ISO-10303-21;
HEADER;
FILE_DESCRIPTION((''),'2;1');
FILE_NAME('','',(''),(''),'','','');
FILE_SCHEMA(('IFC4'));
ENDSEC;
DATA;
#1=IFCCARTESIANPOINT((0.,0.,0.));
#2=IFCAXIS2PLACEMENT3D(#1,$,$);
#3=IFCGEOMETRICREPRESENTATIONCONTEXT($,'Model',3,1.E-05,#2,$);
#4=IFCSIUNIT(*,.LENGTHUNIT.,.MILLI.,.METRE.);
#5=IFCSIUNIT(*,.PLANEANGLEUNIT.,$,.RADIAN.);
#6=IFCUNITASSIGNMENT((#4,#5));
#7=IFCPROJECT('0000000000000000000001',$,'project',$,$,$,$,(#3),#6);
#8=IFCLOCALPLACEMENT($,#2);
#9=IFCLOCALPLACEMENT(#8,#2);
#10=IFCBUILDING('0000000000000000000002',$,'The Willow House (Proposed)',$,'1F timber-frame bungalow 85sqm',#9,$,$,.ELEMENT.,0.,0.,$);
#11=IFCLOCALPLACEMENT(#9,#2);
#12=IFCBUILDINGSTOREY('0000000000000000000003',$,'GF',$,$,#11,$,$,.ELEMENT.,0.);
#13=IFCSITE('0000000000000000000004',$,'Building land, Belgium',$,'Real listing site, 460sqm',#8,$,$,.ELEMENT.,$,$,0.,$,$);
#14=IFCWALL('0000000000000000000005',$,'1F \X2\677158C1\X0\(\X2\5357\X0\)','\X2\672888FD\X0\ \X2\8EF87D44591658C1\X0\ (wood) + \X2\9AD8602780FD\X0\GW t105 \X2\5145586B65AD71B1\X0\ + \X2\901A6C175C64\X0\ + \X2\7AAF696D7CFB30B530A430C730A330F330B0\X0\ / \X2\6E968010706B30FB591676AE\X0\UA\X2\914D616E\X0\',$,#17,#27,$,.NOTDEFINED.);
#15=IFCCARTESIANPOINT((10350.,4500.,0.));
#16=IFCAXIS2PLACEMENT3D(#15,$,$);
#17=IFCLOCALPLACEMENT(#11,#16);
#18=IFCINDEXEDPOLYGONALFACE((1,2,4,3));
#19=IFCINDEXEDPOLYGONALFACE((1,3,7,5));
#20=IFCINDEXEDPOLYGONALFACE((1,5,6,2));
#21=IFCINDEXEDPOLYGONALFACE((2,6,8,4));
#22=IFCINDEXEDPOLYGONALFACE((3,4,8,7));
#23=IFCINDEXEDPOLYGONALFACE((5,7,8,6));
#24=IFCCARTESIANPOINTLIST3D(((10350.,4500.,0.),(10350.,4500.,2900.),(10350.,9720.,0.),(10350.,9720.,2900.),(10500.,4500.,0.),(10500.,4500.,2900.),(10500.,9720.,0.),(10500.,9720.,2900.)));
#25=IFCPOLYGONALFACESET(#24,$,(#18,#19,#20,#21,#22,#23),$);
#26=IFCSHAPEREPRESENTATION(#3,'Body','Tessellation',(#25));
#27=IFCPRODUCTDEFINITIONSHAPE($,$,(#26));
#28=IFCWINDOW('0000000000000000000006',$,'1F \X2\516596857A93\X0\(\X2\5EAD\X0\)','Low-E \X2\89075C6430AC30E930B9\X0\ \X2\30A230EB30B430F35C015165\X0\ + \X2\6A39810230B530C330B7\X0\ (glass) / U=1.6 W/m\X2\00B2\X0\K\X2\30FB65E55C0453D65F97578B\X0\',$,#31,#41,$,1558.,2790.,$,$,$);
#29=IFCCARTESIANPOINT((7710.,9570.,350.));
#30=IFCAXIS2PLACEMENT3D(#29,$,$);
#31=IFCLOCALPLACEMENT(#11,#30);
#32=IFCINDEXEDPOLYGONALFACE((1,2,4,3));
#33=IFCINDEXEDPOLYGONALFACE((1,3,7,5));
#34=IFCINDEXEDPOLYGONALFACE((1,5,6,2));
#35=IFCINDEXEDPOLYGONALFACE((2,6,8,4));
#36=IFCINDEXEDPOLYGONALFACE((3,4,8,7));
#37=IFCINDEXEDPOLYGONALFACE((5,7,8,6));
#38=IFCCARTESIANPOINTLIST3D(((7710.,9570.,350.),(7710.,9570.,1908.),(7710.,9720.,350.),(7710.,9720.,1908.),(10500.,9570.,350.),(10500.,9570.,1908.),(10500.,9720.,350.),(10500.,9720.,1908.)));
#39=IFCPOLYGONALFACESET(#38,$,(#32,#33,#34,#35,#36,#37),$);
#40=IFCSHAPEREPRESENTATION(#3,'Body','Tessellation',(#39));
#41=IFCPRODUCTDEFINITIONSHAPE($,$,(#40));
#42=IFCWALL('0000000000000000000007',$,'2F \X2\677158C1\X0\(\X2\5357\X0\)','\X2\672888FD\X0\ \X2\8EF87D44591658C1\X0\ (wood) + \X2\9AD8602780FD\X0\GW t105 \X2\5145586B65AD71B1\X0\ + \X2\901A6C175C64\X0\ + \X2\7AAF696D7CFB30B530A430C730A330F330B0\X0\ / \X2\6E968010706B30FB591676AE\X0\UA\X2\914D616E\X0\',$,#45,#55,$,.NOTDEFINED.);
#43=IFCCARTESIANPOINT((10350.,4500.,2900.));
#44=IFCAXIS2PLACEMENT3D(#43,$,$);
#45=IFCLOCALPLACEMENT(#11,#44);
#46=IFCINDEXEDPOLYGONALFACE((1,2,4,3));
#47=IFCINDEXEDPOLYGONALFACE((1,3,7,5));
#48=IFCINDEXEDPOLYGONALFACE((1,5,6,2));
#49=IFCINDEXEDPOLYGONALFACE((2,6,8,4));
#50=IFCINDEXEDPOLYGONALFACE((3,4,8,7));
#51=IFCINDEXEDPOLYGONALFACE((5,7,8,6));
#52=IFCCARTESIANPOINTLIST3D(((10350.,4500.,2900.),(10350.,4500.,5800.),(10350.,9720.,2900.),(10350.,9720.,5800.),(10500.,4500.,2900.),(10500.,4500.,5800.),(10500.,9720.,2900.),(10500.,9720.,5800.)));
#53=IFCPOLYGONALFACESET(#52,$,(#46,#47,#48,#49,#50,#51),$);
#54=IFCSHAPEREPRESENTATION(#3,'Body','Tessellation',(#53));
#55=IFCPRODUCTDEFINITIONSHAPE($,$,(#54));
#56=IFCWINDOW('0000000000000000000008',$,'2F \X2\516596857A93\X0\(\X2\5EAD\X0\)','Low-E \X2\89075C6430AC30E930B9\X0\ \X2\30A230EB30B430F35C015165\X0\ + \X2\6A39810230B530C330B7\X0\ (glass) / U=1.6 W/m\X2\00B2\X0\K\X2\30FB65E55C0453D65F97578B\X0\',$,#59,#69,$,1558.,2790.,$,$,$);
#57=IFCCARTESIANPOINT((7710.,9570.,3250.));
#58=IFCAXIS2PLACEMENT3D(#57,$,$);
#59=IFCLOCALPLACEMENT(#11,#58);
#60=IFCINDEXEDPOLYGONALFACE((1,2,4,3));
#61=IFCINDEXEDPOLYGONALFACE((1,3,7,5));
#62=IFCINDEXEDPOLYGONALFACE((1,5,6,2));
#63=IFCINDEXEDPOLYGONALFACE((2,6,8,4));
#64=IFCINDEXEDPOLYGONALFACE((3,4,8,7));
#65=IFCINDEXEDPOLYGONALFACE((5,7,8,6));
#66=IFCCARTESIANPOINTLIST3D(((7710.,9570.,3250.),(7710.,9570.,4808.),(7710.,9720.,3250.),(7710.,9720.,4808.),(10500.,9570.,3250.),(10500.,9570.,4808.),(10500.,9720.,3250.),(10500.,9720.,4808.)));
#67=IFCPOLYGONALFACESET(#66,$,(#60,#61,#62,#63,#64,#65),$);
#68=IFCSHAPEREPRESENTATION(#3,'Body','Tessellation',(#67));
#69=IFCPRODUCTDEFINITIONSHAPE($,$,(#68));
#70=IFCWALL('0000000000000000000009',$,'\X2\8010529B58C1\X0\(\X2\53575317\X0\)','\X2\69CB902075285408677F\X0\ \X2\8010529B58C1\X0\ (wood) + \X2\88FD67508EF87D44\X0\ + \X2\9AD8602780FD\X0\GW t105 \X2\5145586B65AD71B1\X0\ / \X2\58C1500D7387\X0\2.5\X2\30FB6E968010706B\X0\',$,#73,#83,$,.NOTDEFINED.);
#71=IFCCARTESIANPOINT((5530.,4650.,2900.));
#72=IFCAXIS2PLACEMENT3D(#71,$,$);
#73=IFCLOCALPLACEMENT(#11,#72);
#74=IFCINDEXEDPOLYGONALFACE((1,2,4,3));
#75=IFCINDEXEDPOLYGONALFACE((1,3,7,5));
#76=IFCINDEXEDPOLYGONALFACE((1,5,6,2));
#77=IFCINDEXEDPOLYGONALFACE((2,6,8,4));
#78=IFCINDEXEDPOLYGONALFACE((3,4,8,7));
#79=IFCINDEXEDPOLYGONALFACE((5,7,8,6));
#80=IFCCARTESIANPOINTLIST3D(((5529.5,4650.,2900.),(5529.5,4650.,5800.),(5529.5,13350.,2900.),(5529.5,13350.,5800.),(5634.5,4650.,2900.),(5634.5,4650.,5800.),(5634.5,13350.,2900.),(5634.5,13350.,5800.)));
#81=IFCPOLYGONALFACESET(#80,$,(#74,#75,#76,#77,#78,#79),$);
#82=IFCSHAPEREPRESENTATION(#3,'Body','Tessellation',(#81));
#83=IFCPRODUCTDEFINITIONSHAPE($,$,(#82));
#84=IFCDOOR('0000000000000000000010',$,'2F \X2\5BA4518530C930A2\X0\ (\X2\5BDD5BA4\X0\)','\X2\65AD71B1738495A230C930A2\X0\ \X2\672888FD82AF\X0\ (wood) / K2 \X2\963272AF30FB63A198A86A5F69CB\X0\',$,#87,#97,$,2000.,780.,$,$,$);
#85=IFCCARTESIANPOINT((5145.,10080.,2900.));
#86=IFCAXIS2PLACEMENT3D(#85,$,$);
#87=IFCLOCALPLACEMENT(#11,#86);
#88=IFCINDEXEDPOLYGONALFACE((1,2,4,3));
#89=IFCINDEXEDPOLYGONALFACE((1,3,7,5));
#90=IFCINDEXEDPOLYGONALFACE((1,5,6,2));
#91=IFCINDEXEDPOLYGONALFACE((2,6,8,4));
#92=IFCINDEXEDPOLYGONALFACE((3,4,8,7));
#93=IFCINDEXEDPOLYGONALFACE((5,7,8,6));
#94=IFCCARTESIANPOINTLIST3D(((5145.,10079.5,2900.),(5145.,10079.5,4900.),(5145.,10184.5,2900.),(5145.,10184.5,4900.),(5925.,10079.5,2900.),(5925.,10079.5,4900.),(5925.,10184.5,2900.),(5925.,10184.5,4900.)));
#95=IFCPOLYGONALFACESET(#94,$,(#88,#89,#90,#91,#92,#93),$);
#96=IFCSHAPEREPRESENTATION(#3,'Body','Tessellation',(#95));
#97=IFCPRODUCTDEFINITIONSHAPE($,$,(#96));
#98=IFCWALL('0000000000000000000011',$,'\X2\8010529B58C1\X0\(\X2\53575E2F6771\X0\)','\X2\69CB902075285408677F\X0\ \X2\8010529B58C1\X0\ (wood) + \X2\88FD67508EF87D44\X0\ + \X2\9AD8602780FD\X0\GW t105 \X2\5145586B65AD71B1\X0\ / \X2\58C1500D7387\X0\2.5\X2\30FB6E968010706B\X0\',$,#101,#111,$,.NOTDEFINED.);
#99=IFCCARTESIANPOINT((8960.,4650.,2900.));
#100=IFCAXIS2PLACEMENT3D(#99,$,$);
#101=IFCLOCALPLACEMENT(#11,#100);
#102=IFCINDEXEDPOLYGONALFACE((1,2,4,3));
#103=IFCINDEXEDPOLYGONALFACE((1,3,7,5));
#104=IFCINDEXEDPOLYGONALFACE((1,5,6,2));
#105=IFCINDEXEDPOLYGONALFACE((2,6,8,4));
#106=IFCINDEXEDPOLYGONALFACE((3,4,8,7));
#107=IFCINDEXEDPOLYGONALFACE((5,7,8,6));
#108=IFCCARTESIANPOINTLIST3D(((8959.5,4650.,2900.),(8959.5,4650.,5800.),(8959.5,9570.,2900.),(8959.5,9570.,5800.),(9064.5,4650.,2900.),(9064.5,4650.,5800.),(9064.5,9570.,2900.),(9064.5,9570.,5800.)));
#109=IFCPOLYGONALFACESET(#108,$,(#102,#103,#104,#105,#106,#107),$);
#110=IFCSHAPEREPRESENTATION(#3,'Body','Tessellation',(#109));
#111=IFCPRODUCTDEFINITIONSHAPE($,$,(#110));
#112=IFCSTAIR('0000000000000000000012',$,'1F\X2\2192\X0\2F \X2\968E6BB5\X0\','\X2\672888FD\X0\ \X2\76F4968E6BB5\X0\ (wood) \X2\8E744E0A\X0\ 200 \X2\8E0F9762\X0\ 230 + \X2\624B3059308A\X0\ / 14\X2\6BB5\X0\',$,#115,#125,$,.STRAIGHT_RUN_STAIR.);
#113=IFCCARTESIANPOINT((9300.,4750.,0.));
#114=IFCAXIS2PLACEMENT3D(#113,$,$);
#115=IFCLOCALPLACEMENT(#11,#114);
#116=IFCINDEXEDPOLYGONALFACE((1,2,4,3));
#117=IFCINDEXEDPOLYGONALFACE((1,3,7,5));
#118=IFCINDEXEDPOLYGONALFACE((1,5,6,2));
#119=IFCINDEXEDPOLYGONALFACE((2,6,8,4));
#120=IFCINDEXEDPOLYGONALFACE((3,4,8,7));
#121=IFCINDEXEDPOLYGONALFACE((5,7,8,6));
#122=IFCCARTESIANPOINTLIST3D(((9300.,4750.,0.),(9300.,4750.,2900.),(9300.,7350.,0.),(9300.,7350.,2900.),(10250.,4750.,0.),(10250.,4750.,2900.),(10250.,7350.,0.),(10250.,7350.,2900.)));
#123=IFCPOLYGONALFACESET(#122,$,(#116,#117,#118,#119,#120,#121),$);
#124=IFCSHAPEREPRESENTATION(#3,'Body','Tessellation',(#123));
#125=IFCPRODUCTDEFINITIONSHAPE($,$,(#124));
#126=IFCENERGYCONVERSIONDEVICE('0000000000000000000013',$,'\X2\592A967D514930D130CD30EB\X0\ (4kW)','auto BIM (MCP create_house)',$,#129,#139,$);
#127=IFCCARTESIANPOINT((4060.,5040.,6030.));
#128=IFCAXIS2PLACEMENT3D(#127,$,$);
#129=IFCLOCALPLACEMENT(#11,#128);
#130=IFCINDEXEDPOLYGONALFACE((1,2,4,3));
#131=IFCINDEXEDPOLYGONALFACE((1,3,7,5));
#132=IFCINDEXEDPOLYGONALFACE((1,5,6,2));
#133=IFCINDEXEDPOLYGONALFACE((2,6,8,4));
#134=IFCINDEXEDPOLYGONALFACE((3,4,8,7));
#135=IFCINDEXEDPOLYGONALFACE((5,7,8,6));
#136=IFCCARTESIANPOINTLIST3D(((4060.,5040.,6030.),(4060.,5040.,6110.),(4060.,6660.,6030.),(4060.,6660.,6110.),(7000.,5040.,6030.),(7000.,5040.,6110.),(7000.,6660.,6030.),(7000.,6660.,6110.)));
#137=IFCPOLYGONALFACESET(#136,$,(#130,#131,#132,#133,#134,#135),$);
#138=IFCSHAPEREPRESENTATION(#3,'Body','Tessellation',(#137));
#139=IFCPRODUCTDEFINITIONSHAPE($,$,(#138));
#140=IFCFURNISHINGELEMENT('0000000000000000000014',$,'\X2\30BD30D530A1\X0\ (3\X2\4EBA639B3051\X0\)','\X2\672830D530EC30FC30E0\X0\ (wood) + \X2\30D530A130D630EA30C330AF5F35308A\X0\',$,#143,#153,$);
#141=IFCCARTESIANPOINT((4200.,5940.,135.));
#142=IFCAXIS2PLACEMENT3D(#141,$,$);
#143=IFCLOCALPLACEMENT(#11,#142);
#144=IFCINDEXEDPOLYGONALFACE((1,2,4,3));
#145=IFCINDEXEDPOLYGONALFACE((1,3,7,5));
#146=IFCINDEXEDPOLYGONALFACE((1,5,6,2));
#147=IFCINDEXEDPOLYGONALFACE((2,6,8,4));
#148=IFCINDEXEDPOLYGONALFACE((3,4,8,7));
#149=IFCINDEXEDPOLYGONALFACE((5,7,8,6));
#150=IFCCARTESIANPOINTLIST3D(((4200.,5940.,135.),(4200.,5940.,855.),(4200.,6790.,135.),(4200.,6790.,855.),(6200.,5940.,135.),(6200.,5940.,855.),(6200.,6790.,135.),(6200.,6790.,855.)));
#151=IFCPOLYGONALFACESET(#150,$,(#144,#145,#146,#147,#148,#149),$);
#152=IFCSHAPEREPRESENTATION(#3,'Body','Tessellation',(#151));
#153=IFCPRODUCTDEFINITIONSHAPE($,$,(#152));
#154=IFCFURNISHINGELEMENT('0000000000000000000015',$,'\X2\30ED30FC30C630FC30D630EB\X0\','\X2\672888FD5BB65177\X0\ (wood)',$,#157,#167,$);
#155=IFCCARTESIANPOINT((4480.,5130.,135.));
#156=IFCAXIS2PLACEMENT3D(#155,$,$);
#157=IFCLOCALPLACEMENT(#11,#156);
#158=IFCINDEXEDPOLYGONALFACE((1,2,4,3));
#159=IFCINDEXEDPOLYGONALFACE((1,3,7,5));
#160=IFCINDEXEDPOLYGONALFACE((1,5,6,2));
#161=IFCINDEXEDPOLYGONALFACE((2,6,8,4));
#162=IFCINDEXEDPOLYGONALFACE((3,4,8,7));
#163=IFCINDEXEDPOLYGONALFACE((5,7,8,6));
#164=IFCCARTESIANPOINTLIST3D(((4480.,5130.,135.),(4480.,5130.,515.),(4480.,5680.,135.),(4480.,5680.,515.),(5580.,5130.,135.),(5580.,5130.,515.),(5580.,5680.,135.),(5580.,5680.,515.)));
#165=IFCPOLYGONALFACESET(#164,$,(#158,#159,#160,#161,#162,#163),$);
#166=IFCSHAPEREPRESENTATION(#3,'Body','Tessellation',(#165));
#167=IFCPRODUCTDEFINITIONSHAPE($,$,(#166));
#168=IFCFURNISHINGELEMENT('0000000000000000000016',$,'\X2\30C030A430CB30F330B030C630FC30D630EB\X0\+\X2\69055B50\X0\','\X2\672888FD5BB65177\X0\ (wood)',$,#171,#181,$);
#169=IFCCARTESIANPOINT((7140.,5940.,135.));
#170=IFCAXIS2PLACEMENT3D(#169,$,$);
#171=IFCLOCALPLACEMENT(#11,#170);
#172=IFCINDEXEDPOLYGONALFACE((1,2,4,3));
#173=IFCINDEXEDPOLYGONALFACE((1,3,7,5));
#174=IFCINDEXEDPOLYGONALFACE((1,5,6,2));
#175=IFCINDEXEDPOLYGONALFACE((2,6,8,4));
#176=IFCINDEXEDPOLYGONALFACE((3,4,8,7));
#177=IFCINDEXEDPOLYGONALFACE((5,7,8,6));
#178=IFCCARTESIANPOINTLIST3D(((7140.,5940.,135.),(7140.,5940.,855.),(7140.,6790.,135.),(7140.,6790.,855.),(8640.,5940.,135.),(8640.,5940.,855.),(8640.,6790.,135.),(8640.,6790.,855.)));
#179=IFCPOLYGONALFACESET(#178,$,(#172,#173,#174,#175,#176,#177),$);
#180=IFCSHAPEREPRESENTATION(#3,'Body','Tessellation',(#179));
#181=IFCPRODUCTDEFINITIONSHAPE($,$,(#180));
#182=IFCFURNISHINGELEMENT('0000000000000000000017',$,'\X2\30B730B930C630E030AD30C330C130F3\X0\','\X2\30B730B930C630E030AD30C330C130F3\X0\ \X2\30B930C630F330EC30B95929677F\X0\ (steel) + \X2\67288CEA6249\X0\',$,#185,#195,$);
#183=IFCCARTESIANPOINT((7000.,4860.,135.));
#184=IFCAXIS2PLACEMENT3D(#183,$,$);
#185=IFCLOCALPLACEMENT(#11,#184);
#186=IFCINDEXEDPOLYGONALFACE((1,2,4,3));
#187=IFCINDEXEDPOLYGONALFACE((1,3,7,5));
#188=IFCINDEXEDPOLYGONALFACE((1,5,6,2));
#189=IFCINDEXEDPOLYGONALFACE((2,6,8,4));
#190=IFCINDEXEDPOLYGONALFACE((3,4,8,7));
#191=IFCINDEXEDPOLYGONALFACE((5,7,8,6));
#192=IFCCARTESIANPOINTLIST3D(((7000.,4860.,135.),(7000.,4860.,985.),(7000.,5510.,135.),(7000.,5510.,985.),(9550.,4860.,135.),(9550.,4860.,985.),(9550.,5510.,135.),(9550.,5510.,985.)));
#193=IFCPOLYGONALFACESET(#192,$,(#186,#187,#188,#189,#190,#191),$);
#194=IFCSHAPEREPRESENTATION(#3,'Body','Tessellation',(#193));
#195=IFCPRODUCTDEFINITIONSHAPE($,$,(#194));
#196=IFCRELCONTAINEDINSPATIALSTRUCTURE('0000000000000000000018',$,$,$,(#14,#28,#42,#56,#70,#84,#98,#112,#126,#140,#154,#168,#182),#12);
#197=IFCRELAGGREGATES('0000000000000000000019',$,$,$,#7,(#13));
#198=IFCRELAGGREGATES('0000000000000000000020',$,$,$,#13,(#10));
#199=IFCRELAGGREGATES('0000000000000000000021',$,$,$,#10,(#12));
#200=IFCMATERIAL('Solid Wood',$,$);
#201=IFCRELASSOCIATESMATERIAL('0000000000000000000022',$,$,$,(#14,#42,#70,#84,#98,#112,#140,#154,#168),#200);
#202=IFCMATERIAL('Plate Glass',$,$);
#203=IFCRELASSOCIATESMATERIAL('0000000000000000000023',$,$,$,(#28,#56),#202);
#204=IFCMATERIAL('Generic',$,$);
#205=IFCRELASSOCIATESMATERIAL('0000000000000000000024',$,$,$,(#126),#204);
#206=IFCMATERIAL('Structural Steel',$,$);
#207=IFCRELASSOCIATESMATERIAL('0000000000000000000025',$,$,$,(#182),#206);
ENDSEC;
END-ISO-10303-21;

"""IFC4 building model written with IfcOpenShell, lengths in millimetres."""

from ifc_helpers import new_model, si_unit, frame, frame_2d, origin, place, context, project, spatial, rectangle, extrude, material, element, fill, save


model = new_model("IFC4")

# Units and contexts
model_context = context("Model", 3, precision=1e-05, world=origin())
ifc_project = project(units=[si_unit("LENGTHUNIT", "METRE", prefix="MILLI"), si_unit("PLANEANGLEUNIT", "RADIAN")], contexts=[model_context])

# Site, building, storey
site_placement = place(None, origin())
site = spatial("IfcSite", under=ifc_project, at=site_placement, Name="Building land, Belgium", ObjectType="Real listing site, 460sqm", CompositionType="ELEMENT", RefElevation=0.0)
building_placement = place(site_placement, origin())
building = spatial("IfcBuilding", under=site, at=building_placement, Name="The Willow House (Proposed)", ObjectType="1F timber-frame bungalow 85sqm", CompositionType="ELEMENT", ElevationOfRefHeight=0.0, ElevationOfTerrain=0.0)
storey_placement = place(building_placement, origin())
storey = spatial("IfcBuildingStorey", under=building, at=storey_placement, Name="GF", CompositionType="ELEMENT", Elevation=0.0)

# Wall, opening, window
ifc_material_1 = material(Name="Solid Wood")
wall_1_placement = place(storey_placement, frame((10350.0, 4500.0, 0.0)))
wall_1 = element("IfcWall", 1, at=wall_1_placement, inside=storey, material=ifc_material_1, Name="1F 東壁(南)", Description="木製 軸組外壁 (wood) + 高性能GW t105 充填断熱 + 通気層 + 窯業系サイディング / 準耐火・外皮UA配慮", PredefinedType="NOTDEFINED", context=model_context, shape_type="SweptSolid", body=[
    extrude(rectangle(XDim=150.0, YDim=5220.0, at=frame_2d((75.0, 2610.0))), frame((10350.0, 4500.0, 0.0)), (0.0, 0.0, 1.0), 2900.0),
])
opening_1_placement = place(storey_placement, frame((7710.0, 9570.0, 350.0)))
opening_1 = element("IfcOpeningElement", 2, at=opening_1_placement, cuts=wall_1, PredefinedType="NOTDEFINED", context=model_context, shape_type="SweptSolid", body=[
    extrude(rectangle(XDim=2790.0, YDim=150.0, at=frame_2d((1395.0, 75.0))), frame((7710.0, 9570.0, 350.0)), (0.0, 0.0, 1.0), 1558.0),
])
ifc_material_2 = material(Name="Plate Glass")
window_1_placement = place(storey_placement, frame((7710.0, 9570.0, 350.0)))
window_1 = element("IfcWindow", 3, at=window_1_placement, inside=storey, material=ifc_material_2, Name="1F 入隅窓(庭)", Description="Low-E 複層ガラス アルゴン封入 + 樹脂サッシ (glass) / U=1.6 W/m²K・日射取得型", OverallHeight=1558.0, OverallWidth=2790.0, context=model_context, shape_type="SweptSolid", body=[
    extrude(rectangle(XDim=2790.0, YDim=150.0, at=frame_2d((1395.0, 75.0))), frame((7710.0, 9570.0, 350.0)), (0.0, 0.0, 1.0), 1558.0),
])
fill(opening_1, window_1)

# Wall, opening, window
wall_2_placement = place(storey_placement, frame((10350.0, 4500.0, 2900.0)))
wall_2 = element("IfcWall", 4, at=wall_2_placement, inside=storey, material=ifc_material_1, Name="2F 東壁(南)", Description="木製 軸組外壁 (wood) + 高性能GW t105 充填断熱 + 通気層 + 窯業系サイディング / 準耐火・外皮UA配慮", PredefinedType="NOTDEFINED", context=model_context, shape_type="SweptSolid", body=[
    extrude(rectangle(XDim=150.0, YDim=5220.0, at=frame_2d((75.0, 2610.0))), frame((10350.0, 4500.0, 2900.0)), (0.0, 0.0, 1.0), 2900.0),
])
opening_2_placement = place(storey_placement, frame((7710.0, 9570.0, 3250.0)))
opening_2 = element("IfcOpeningElement", 5, at=opening_2_placement, cuts=wall_2, PredefinedType="NOTDEFINED", context=model_context, shape_type="SweptSolid", body=[
    extrude(rectangle(XDim=2790.0, YDim=150.0, at=frame_2d((1395.0, 75.0))), frame((7710.0, 9570.0, 3250.0)), (0.0, 0.0, 1.0), 1558.0),
])
window_2_placement = place(storey_placement, frame((7710.0, 9570.0, 3250.0)))
window_2 = element("IfcWindow", 6, at=window_2_placement, inside=storey, material=ifc_material_2, Name="2F 入隅窓(庭)", Description="Low-E 複層ガラス アルゴン封入 + 樹脂サッシ (glass) / U=1.6 W/m²K・日射取得型", OverallHeight=1558.0, OverallWidth=2790.0, context=model_context, shape_type="SweptSolid", body=[
    extrude(rectangle(XDim=2790.0, YDim=150.0, at=frame_2d((1395.0, 75.0))), frame((7710.0, 9570.0, 3250.0)), (0.0, 0.0, 1.0), 1558.0),
])
fill(opening_2, window_2)

# Wall, opening, door
wall_3_placement = place(storey_placement, frame((5530.0, 4650.0, 2900.0)))
wall_3 = element("IfcWall", 7, at=wall_3_placement, inside=storey, material=ifc_material_1, Name="耐力壁(南北)", Description="構造用合板 耐力壁 (wood) + 製材軸組 + 高性能GW t105 充填断熱 / 壁倍率2.5・準耐火", PredefinedType="NOTDEFINED", context=model_context, shape_type="SweptSolid", body=[
    extrude(rectangle(XDim=105.0, YDim=8700.0, at=frame_2d((52.0, 4350.0))), frame((5530.0, 4650.0, 2900.0)), (0.0, 0.0, 1.0), 2900.0),
])
opening_3_placement = place(storey_placement, frame((5145.0, 10080.0, 2900.0)))
opening_3 = element("IfcOpeningElement", 8, at=opening_3_placement, cuts=wall_3, PredefinedType="NOTDEFINED", context=model_context, shape_type="SweptSolid", body=[
    extrude(rectangle(XDim=780.0, YDim=105.0, at=frame_2d((390.0, 52.0))), frame((5145.0, 10080.0, 2900.0)), (0.0, 0.0, 1.0), 2000.0),
])
door_1_placement = place(storey_placement, frame((5145.0, 10080.0, 2900.0)))
door_1 = element("IfcDoor", 9, at=door_1_placement, inside=storey, material=ifc_material_1, Name="2F 室内ドア (寝室)", Description="断熱玄関ドア 木製芯 (wood) / K2 防犯・採風機構", OverallHeight=2000.0, OverallWidth=780.0, context=model_context, shape_type="SweptSolid", body=[
    extrude(rectangle(XDim=780.0, YDim=105.0, at=frame_2d((390.0, 52.0))), frame((5145.0, 10080.0, 2900.0)), (0.0, 0.0, 1.0), 2000.0),
])
fill(opening_3, door_1)

# Wall
wall_4_placement = place(storey_placement, frame((8960.0, 4650.0, 2900.0)))
element("IfcWall", 10, at=wall_4_placement, inside=storey, material=ifc_material_1, Name="耐力壁(南帯東)", Description="構造用合板 耐力壁 (wood) + 製材軸組 + 高性能GW t105 充填断熱 / 壁倍率2.5・準耐火", PredefinedType="NOTDEFINED", context=model_context, shape_type="SweptSolid", body=[
    extrude(rectangle(XDim=105.0, YDim=4920.0, at=frame_2d((52.0, 2460.0))), frame((8960.0, 4650.0, 2900.0)), (0.0, 0.0, 1.0), 2900.0),
])

# Stair
stair_placement = place(storey_placement, frame((9300.0, 4750.0, 0.0)))
element("IfcStair", 11, at=stair_placement, inside=storey, material=ifc_material_1, Name="1F→2F 階段", Description="木製 直階段 (wood) 蹴上 200 踏面 230 + 手すり / 14段", PredefinedType="STRAIGHT_RUN_STAIR", context=model_context, shape_type="SweptSolid", body=[
    extrude(rectangle(XDim=950.0, YDim=2600.0, at=frame_2d((475.0, 1300.0))), frame((9300.0, 4750.0, 0.0)), (0.0, 0.0, 1.0), 2900.0),
])

# Energy conversion device
ifc_material_3 = material(Name="Generic")
energy_conversion_device_placement = place(storey_placement, frame((4060.0, 5040.0, 6030.0)))
element("IfcEnergyConversionDevice", 12, at=energy_conversion_device_placement, inside=storey, material=ifc_material_3, Name="太陽光パネル (4kW)", Description="auto BIM (MCP create_house)", context=model_context, shape_type="SweptSolid", body=[
    extrude(rectangle(XDim=2940.0, YDim=1620.0, at=frame_2d((1470.0, 810.0))), frame((4060.0, 5040.0, 6030.0)), (0.0, 0.0, 1.0), 80.0),
])

# Furnishing elements
furnishing_1_placement = place(storey_placement, frame((4200.0, 5940.0, 135.0)))
element("IfcFurnishingElement", 13, at=furnishing_1_placement, inside=storey, material=ifc_material_1, Name="ソファ (3人掛け)", Description="木フレーム (wood) + ファブリック張り", context=model_context, shape_type="SweptSolid", body=[
    extrude(rectangle(XDim=2000.0, YDim=850.0, at=frame_2d((1000.0, 425.0))), frame((4200.0, 5940.0, 135.0)), (0.0, 0.0, 1.0), 720.0),
])
furnishing_2_placement = place(storey_placement, frame((4480.0, 5130.0, 135.0)))
element("IfcFurnishingElement", 14, at=furnishing_2_placement, inside=storey, material=ifc_material_1, Name="ローテーブル", Description="木製家具 (wood)", context=model_context, shape_type="SweptSolid", body=[
    extrude(rectangle(XDim=1100.0, YDim=550.0, at=frame_2d((550.0, 275.0))), frame((4480.0, 5130.0, 135.0)), (0.0, 0.0, 1.0), 380.0),
])
furnishing_3_placement = place(storey_placement, frame((7140.0, 5940.0, 135.0)))
element("IfcFurnishingElement", 15, at=furnishing_3_placement, inside=storey, material=ifc_material_1, Name="ダイニングテーブル+椅子", Description="木製家具 (wood)", context=model_context, shape_type="SweptSolid", body=[
    extrude(rectangle(XDim=1500.0, YDim=850.0, at=frame_2d((750.0, 425.0))), frame((7140.0, 5940.0, 135.0)), (0.0, 0.0, 1.0), 720.0),
])
ifc_material_4 = material(Name="Structural Steel")
furnishing_4_placement = place(storey_placement, frame((7000.0, 4860.0, 135.0)))
element("IfcFurnishingElement", 16, at=furnishing_4_placement, inside=storey, material=ifc_material_4, Name="システムキッチン", Description="システムキッチン ステンレス天板 (steel) + 木質扉", context=model_context, shape_type="SweptSolid", body=[
    extrude(rectangle(XDim=2550.0, YDim=650.0, at=frame_2d((1275.0, 325.0))), frame((7000.0, 4860.0, 135.0)), (0.0, 0.0, 1.0), 850.0),
])

save(model, "model.ifc")
